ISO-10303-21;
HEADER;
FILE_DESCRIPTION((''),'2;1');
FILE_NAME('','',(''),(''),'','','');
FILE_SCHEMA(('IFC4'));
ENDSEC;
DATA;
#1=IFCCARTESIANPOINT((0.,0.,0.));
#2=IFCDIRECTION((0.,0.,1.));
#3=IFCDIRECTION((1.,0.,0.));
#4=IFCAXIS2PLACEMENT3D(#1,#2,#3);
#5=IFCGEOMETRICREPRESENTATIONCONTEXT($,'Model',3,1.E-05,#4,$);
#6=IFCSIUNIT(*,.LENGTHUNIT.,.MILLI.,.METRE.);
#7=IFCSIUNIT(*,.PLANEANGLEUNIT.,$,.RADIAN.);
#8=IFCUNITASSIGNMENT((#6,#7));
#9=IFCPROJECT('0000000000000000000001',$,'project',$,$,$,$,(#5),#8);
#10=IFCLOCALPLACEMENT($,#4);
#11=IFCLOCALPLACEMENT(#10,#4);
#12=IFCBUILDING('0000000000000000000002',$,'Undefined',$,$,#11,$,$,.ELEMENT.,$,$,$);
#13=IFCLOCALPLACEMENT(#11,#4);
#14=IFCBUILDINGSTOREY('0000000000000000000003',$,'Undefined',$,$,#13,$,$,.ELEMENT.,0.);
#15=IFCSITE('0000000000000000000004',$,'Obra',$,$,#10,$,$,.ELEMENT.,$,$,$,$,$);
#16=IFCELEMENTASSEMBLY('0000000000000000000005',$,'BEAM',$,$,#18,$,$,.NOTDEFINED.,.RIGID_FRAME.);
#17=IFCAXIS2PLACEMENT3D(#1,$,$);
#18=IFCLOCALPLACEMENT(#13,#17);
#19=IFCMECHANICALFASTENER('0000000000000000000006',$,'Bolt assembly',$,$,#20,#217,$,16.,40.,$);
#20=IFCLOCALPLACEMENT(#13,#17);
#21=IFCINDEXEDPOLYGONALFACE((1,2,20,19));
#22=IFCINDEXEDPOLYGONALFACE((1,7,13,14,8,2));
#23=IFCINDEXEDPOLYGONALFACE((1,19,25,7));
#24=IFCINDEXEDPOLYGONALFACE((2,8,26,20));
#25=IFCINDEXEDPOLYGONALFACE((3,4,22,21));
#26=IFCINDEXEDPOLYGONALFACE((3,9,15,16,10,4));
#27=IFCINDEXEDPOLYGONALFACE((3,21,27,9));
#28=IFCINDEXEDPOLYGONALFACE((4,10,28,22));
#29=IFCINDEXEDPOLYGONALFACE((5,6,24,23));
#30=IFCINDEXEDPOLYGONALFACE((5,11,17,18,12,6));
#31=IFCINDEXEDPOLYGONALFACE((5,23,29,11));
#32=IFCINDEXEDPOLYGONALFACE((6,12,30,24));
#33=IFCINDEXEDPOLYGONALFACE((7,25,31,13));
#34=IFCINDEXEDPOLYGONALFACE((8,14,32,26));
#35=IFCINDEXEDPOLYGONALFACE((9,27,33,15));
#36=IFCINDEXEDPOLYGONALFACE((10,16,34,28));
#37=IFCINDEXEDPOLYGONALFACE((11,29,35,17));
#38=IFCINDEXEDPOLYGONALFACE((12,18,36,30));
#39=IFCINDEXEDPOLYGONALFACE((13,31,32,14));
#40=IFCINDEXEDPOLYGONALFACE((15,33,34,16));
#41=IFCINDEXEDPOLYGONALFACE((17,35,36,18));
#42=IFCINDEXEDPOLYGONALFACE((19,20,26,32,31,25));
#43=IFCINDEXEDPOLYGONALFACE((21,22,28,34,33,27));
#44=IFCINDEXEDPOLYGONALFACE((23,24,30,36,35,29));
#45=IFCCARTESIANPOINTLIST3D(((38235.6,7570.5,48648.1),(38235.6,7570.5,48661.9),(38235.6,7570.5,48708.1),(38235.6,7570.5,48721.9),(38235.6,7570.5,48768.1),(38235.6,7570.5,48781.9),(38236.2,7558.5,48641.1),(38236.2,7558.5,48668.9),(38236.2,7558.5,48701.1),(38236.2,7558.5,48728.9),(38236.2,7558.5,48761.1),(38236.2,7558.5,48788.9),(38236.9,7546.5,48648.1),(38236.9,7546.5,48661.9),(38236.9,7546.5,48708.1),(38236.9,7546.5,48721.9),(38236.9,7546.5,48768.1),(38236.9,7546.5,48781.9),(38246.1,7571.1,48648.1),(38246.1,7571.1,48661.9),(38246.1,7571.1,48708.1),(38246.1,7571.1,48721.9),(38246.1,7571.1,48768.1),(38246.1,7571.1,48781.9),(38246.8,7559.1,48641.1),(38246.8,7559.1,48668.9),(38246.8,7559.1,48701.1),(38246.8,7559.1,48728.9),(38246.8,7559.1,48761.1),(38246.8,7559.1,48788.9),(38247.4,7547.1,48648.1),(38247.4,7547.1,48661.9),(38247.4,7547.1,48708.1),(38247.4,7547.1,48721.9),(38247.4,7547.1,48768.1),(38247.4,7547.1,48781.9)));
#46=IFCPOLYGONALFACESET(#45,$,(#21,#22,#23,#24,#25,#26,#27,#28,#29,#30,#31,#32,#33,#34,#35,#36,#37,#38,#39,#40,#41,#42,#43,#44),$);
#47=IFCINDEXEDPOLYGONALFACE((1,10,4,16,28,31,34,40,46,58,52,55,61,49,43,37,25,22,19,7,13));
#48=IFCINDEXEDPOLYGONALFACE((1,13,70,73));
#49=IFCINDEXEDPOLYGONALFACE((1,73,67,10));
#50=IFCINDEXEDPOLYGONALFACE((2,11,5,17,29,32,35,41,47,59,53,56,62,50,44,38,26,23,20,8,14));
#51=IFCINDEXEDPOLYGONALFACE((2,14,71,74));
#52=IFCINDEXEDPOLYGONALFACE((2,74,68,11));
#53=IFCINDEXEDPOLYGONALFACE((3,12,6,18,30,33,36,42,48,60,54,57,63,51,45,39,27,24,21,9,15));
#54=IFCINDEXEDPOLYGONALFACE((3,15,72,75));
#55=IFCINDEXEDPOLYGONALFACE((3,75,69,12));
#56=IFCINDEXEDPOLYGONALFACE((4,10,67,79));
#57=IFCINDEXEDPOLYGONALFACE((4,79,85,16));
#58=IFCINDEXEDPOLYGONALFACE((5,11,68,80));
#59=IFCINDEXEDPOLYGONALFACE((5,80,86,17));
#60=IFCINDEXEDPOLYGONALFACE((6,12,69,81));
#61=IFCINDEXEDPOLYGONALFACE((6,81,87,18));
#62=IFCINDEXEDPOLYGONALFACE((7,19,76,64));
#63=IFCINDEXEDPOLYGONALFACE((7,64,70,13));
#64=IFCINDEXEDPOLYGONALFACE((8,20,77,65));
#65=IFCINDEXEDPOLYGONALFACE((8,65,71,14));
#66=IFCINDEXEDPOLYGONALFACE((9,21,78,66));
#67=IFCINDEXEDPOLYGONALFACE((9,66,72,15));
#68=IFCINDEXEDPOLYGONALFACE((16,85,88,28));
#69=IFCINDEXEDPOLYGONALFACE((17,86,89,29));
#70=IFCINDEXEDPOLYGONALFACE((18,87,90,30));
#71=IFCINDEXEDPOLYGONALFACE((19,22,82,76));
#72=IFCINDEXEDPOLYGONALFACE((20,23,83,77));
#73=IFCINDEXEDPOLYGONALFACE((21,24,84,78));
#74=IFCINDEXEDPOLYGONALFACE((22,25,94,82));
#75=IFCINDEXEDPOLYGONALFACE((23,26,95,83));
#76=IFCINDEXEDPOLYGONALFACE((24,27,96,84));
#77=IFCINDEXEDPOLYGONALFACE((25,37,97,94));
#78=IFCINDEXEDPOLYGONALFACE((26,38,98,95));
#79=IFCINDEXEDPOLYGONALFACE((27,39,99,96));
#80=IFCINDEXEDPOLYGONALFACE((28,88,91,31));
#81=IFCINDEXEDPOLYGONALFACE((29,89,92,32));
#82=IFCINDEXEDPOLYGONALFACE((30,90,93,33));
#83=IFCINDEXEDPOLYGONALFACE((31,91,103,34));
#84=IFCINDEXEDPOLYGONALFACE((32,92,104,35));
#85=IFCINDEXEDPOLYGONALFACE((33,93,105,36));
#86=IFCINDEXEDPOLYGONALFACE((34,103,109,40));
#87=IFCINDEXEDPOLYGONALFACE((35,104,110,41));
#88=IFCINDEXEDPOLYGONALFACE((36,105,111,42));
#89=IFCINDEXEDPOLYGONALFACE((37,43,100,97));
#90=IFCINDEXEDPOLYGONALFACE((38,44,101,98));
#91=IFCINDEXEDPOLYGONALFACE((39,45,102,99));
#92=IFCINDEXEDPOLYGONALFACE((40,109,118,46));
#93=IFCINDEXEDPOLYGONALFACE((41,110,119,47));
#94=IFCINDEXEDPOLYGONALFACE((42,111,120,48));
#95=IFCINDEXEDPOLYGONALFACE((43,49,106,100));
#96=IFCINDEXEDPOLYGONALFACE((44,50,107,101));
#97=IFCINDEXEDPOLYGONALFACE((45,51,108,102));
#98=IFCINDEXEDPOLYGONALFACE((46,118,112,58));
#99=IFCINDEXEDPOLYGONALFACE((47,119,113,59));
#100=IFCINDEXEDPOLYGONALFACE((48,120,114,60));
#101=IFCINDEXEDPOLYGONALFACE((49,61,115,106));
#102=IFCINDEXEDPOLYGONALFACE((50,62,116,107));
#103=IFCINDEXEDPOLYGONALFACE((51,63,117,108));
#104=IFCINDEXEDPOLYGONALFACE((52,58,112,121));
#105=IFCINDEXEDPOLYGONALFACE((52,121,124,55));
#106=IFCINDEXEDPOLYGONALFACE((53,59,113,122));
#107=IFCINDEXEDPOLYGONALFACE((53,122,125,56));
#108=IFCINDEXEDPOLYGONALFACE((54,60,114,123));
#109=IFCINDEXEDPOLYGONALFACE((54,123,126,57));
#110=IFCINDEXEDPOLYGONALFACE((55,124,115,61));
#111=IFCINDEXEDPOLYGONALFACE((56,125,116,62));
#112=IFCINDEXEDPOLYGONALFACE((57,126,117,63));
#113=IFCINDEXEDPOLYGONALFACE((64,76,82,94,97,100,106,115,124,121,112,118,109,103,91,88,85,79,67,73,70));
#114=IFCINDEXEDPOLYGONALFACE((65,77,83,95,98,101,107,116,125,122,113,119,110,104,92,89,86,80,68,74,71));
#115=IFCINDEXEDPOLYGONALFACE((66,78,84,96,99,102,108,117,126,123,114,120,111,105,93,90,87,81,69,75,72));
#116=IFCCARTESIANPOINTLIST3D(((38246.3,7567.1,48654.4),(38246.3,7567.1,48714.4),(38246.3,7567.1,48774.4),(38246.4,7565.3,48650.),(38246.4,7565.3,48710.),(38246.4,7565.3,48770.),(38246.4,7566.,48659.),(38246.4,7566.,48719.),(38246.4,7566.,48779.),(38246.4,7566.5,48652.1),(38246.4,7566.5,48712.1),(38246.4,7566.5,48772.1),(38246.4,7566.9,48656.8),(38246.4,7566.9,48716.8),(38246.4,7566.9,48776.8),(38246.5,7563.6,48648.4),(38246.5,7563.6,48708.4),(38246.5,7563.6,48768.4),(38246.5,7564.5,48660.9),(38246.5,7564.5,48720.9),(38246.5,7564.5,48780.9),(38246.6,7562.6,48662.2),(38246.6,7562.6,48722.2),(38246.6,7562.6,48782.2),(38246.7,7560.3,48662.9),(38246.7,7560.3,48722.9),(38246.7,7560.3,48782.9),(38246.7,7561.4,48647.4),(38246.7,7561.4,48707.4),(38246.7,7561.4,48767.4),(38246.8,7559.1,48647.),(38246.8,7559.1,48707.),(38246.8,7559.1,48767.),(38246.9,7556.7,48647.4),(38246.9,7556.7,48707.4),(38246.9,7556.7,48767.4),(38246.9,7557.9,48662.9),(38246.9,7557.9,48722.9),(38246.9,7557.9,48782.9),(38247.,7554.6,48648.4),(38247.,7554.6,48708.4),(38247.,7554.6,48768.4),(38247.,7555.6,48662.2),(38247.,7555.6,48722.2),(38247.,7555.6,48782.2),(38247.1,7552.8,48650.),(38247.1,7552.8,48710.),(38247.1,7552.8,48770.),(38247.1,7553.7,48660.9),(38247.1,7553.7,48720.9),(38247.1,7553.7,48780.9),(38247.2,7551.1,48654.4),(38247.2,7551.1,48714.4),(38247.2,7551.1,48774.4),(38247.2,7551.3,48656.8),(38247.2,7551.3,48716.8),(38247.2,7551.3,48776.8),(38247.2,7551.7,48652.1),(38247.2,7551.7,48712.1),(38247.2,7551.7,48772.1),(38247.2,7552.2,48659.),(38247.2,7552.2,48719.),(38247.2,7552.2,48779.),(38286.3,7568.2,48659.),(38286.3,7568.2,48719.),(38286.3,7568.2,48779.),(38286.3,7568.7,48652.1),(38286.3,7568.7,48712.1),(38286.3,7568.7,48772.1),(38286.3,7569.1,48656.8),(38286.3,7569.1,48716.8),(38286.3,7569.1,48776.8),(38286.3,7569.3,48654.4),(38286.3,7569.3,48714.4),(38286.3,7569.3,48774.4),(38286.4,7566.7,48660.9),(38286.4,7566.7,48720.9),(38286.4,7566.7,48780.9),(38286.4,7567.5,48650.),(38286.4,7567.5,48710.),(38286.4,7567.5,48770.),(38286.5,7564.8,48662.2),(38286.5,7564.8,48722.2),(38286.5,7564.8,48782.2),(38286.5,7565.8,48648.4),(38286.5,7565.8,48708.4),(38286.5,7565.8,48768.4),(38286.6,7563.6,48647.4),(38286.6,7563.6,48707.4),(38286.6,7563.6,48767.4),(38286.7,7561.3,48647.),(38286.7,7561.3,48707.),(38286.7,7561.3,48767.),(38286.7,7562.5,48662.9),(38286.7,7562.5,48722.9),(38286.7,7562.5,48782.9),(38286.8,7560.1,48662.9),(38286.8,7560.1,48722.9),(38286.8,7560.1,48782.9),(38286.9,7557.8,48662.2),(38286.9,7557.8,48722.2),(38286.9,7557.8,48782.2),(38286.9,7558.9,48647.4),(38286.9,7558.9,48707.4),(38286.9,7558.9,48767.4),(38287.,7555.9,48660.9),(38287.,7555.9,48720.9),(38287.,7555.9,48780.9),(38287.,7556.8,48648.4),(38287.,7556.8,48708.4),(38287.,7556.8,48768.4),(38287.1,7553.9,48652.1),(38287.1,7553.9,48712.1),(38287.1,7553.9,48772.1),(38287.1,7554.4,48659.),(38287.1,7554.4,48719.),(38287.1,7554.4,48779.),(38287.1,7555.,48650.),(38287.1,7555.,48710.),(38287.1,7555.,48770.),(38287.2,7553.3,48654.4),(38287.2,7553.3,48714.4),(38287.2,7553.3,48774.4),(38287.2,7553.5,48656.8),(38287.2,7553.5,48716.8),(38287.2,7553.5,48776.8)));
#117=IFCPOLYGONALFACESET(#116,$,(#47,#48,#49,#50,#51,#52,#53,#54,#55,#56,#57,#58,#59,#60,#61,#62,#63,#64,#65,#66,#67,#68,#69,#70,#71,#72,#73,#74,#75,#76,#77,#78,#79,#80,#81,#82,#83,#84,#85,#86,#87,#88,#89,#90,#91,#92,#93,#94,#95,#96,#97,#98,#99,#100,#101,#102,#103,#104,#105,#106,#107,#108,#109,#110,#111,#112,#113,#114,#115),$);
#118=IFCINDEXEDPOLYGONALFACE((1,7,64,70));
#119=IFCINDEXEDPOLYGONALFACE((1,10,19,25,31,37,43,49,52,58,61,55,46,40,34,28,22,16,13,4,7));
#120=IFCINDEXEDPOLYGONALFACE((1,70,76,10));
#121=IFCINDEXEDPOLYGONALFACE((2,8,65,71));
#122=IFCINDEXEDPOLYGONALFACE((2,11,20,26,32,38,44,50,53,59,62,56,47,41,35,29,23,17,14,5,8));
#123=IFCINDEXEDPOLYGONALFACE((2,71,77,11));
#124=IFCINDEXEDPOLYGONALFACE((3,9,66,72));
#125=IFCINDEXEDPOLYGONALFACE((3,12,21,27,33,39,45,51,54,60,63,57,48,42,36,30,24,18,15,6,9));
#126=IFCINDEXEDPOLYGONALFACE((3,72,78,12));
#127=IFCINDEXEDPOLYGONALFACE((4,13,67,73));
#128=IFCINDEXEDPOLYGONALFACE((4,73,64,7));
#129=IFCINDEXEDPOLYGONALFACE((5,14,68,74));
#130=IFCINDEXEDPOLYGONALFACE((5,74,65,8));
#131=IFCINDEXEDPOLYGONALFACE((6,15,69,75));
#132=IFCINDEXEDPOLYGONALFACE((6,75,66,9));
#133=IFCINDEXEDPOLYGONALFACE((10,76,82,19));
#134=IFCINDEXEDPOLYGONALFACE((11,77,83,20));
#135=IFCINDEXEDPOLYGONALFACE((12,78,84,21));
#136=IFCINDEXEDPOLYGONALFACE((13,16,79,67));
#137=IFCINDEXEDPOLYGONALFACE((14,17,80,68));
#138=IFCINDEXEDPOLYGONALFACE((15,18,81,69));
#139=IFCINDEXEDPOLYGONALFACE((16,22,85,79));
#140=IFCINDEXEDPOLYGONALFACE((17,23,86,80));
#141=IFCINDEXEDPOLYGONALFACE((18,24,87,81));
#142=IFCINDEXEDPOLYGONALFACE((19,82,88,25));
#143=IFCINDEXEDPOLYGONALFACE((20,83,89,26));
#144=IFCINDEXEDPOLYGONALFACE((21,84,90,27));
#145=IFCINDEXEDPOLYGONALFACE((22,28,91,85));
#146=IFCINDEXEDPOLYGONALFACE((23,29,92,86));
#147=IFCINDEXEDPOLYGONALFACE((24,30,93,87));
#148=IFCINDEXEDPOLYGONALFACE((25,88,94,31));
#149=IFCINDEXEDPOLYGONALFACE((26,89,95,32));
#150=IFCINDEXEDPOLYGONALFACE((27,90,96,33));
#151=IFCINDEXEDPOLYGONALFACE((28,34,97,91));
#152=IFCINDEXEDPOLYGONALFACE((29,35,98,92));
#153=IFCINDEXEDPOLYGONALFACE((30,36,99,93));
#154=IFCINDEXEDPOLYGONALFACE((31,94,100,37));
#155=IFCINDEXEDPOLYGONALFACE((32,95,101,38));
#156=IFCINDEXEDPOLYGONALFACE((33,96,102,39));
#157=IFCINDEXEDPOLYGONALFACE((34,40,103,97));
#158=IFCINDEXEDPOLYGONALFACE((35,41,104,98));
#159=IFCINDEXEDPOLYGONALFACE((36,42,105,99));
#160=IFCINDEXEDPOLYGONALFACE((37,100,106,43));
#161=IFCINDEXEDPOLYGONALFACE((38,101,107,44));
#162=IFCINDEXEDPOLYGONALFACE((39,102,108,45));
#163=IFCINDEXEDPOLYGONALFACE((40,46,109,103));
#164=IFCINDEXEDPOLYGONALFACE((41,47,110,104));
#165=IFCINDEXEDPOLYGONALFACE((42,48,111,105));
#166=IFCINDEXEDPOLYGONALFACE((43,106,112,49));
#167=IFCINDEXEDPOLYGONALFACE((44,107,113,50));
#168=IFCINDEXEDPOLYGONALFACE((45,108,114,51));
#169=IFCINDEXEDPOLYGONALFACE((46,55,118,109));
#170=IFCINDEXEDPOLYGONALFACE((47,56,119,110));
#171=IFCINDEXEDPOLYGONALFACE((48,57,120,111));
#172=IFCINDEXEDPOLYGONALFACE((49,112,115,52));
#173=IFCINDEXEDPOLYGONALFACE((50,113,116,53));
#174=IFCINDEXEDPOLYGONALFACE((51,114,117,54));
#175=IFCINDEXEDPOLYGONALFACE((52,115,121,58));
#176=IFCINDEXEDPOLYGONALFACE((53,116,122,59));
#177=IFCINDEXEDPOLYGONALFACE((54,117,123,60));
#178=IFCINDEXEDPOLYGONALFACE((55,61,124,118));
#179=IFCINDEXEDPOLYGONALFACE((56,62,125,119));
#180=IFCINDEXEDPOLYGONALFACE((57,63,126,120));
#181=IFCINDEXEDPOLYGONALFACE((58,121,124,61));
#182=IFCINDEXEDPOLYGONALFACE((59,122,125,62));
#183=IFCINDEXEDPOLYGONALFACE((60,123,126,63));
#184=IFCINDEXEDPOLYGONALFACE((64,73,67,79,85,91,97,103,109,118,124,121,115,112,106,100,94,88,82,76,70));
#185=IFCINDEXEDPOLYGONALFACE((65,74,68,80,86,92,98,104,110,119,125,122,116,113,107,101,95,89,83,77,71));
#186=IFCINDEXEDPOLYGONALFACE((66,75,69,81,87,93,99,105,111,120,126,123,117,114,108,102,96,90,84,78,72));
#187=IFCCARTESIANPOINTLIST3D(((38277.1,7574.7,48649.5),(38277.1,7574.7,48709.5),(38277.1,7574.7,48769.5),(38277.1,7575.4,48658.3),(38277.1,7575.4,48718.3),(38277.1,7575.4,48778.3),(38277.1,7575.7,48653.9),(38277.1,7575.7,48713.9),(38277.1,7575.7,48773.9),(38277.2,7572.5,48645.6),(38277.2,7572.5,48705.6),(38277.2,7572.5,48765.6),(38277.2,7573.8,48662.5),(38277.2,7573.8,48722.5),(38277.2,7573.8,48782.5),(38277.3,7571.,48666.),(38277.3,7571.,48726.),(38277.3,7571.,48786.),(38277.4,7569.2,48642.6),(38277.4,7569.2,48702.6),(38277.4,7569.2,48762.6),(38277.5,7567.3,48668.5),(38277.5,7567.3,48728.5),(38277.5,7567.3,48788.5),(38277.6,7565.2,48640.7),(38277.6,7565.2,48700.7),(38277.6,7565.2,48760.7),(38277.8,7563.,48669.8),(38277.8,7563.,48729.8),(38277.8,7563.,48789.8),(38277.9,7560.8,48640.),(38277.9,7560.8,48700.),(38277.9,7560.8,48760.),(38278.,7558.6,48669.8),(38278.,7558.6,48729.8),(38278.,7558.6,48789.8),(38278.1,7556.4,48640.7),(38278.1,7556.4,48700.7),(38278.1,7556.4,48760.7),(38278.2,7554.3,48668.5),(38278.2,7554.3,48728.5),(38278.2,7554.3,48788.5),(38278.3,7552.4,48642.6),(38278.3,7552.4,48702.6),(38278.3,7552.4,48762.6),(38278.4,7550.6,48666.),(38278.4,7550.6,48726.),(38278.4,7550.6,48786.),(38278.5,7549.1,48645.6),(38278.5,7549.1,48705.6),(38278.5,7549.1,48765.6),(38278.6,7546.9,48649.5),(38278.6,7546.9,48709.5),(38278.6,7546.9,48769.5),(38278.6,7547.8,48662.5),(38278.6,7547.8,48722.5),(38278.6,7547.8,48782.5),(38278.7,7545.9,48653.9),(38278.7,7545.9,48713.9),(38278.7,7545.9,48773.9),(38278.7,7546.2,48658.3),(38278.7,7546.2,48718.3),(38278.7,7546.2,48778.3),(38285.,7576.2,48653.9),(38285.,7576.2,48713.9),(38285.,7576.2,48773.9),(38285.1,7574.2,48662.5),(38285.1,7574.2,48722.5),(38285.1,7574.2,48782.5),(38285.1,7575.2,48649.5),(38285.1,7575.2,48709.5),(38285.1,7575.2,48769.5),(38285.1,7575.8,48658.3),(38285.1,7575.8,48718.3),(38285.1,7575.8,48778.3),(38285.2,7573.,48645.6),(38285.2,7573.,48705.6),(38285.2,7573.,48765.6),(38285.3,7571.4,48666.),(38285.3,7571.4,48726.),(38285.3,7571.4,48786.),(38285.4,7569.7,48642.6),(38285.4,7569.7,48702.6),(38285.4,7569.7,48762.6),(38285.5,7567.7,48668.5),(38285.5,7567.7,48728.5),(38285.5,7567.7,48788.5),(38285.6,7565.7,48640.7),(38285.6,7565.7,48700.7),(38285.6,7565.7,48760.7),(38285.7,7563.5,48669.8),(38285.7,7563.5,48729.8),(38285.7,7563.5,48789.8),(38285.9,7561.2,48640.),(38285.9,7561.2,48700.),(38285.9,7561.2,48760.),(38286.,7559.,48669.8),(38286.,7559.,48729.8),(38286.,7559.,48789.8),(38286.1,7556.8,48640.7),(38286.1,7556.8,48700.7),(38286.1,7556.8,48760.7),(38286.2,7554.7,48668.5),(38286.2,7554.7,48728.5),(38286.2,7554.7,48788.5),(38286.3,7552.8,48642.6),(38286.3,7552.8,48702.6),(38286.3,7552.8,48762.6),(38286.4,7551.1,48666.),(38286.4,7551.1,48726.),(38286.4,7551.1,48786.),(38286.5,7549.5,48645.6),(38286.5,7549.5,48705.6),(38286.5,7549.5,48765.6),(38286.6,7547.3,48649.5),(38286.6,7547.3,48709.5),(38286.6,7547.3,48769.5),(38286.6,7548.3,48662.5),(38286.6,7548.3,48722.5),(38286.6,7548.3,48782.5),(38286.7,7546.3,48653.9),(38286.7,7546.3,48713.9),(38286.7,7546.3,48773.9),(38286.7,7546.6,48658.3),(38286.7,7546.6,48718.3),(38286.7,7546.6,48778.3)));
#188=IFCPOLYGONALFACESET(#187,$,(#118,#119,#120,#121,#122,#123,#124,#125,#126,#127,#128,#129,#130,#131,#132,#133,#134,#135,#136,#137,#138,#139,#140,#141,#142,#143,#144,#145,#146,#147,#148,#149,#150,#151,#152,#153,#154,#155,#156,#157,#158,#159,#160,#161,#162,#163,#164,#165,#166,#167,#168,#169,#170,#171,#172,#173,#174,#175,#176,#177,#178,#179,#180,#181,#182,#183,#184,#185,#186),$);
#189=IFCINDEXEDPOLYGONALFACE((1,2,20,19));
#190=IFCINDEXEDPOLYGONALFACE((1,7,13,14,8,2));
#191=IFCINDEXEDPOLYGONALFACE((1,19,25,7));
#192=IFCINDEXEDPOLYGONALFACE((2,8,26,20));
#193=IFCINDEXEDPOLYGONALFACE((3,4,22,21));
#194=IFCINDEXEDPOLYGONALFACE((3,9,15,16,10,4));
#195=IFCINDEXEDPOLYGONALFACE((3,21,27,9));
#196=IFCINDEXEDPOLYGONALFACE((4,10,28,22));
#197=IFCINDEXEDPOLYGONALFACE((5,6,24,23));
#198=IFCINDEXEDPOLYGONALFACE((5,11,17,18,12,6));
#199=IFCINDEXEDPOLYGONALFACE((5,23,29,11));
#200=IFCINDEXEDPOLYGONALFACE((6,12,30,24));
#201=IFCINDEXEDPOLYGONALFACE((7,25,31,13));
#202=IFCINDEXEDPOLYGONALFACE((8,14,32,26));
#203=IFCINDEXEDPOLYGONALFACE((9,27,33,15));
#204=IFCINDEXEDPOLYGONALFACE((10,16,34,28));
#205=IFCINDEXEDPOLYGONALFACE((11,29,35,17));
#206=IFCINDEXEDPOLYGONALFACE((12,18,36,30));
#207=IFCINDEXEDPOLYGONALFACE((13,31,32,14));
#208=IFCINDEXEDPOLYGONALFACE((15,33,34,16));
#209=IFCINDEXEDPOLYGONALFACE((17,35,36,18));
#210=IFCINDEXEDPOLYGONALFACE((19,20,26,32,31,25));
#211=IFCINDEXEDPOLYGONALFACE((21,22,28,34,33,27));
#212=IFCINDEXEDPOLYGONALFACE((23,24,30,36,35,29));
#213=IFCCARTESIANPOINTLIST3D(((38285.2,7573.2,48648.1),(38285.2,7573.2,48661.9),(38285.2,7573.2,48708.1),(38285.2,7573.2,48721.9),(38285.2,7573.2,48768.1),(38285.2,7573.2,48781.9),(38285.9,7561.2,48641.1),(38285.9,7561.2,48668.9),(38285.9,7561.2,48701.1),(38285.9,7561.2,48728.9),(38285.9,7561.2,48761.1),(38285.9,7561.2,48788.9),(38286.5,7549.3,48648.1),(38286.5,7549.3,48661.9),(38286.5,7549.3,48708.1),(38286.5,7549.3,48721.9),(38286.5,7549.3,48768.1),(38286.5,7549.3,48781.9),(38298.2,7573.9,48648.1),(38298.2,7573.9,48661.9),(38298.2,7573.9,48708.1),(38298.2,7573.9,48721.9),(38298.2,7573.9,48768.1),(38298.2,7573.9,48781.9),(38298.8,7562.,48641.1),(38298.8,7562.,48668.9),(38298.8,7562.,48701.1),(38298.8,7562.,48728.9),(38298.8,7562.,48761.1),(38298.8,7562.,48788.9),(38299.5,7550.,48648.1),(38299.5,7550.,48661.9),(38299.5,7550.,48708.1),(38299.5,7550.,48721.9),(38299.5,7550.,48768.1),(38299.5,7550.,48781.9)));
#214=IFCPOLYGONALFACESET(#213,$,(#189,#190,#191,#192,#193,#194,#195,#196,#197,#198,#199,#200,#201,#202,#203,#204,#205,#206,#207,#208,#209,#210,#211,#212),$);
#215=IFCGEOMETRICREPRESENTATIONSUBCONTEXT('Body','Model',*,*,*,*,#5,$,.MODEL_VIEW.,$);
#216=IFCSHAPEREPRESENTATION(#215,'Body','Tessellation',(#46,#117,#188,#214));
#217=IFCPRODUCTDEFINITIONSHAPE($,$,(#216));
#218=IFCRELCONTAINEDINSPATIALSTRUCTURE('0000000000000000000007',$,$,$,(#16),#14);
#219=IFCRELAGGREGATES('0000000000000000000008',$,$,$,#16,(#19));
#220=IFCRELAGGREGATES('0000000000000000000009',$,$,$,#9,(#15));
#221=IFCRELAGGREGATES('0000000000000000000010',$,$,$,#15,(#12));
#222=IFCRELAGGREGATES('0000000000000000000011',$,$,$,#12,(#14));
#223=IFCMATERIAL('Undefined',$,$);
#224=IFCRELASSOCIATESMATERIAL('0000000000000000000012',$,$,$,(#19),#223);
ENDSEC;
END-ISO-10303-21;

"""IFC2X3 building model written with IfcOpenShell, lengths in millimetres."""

from ifc_helpers import new_model, si_unit, frame, origin_with_axes, origin_2d_with_axis, place, context, subcontext, project, spatial, polyline, circle, outline, extrude, source, transform, mapped, material, element, aggregate, save


model = new_model("IFC2X3")

# Units and contexts
model_context = context("Model", 3, precision=1e-05, world=origin_with_axes())
body_context = subcontext(model_context, "Body", "Model", "MODEL_VIEW")
ifc_project = project(units=[si_unit("LENGTHUNIT", "METRE", prefix="MILLI"), si_unit("PLANEANGLEUNIT", "RADIAN")], contexts=[model_context])

# Site, building, storey
site_placement = place(None, origin_with_axes())
site = spatial("IfcSite", under=ifc_project, at=site_placement, Name="Obra", CompositionType="ELEMENT")
building_placement = place(site_placement, origin_with_axes())
building = spatial("IfcBuilding", under=site, at=building_placement, Name="Undefined", CompositionType="ELEMENT")
storey_placement = place(building_placement, origin_with_axes())
storey = spatial("IfcBuildingStorey", under=building, at=storey_placement, Name="Undefined", CompositionType="ELEMENT", Elevation=0.0)

# Shared definitions
ifc_material_1 = material(Name="Undefined")
shared_shape_1 = source(origin_with_axes(), body_context, "Body", "SweptSolid", [
    extrude(outline(polyline([(13.9, 0.0), (6.9, 12.0), (-6.9, 12.0), (-13.9, 0.0), (-6.9, -12.0), (6.9, -12.0), (13.9, 0.0)])), frame((0.0, -44.8, 0.0), z_axis=(0.0, 1.0, 0.0), x_axis=(1.0, 0.0, 0.0)), (0.0, 0.0, 1.0), 10.6),
    extrude(circle(Radius=8.0, at=origin_2d_with_axis()), frame((0.0, -34.2, 0.0), z_axis=(0.0, 1.0, 0.0), x_axis=(1.0, 0.0, 0.0)), (0.0, 0.0, 1.0), 40.0),
    extrude(circle(Radius=15.0, at=origin_2d_with_axis()), frame((0.0, -3.1, 0.0), z_axis=(0.0, 1.0, 0.0), x_axis=(1.0, 0.0, 0.0)), (0.0, 0.0, 1.0), 8.0),
    extrude(outline(polyline([(13.9, 0.0), (6.9, 12.0), (-6.9, 12.0), (-13.9, 0.0), (-6.9, -12.0), (6.9, -12.0), (13.9, 0.0)])), frame((0.0, 4.9, 0.0), z_axis=(0.0, 1.0, 0.0), x_axis=(1.0, 0.0, 0.0)), (0.0, 0.0, 1.0), 13.0),
])

# Element assembly, mechanical fastener
assembly_1_placement = place(storey_placement, origin_with_axes())
assembly_1 = element("IfcElementAssembly", 1, at=assembly_1_placement, inside=storey, Name="BEAM", AssemblyPlace="NOTDEFINED", PredefinedType="RIGID_FRAME")
mechanical_fastener_1_placement = place(assembly_1_placement, frame((38278.2, 7610.9, 48835.0), z_axis=(0.055152, -0.998478, 0.0), x_axis=(0.0, 0.0, -1.0)))
mechanical_fastener_1 = element("IfcMechanicalFastener", 2, at=mechanical_fastener_1_placement, material=ifc_material_1, Name="Bolt assembly", NominalDiameter=16.0, NominalLength=40.0, context=body_context, shape_type="MappedRepresentation", body=[
    mapped(shared_shape_1, transform((60.0, 0.0, 50.0))),
    mapped(shared_shape_1, transform((120.0, 0.0, 50.0))),
    mapped(shared_shape_1, transform((180.0, 0.0, 50.0))),
])
aggregate(assembly_1, [mechanical_fastener_1])

save(model, "model.ifc")
